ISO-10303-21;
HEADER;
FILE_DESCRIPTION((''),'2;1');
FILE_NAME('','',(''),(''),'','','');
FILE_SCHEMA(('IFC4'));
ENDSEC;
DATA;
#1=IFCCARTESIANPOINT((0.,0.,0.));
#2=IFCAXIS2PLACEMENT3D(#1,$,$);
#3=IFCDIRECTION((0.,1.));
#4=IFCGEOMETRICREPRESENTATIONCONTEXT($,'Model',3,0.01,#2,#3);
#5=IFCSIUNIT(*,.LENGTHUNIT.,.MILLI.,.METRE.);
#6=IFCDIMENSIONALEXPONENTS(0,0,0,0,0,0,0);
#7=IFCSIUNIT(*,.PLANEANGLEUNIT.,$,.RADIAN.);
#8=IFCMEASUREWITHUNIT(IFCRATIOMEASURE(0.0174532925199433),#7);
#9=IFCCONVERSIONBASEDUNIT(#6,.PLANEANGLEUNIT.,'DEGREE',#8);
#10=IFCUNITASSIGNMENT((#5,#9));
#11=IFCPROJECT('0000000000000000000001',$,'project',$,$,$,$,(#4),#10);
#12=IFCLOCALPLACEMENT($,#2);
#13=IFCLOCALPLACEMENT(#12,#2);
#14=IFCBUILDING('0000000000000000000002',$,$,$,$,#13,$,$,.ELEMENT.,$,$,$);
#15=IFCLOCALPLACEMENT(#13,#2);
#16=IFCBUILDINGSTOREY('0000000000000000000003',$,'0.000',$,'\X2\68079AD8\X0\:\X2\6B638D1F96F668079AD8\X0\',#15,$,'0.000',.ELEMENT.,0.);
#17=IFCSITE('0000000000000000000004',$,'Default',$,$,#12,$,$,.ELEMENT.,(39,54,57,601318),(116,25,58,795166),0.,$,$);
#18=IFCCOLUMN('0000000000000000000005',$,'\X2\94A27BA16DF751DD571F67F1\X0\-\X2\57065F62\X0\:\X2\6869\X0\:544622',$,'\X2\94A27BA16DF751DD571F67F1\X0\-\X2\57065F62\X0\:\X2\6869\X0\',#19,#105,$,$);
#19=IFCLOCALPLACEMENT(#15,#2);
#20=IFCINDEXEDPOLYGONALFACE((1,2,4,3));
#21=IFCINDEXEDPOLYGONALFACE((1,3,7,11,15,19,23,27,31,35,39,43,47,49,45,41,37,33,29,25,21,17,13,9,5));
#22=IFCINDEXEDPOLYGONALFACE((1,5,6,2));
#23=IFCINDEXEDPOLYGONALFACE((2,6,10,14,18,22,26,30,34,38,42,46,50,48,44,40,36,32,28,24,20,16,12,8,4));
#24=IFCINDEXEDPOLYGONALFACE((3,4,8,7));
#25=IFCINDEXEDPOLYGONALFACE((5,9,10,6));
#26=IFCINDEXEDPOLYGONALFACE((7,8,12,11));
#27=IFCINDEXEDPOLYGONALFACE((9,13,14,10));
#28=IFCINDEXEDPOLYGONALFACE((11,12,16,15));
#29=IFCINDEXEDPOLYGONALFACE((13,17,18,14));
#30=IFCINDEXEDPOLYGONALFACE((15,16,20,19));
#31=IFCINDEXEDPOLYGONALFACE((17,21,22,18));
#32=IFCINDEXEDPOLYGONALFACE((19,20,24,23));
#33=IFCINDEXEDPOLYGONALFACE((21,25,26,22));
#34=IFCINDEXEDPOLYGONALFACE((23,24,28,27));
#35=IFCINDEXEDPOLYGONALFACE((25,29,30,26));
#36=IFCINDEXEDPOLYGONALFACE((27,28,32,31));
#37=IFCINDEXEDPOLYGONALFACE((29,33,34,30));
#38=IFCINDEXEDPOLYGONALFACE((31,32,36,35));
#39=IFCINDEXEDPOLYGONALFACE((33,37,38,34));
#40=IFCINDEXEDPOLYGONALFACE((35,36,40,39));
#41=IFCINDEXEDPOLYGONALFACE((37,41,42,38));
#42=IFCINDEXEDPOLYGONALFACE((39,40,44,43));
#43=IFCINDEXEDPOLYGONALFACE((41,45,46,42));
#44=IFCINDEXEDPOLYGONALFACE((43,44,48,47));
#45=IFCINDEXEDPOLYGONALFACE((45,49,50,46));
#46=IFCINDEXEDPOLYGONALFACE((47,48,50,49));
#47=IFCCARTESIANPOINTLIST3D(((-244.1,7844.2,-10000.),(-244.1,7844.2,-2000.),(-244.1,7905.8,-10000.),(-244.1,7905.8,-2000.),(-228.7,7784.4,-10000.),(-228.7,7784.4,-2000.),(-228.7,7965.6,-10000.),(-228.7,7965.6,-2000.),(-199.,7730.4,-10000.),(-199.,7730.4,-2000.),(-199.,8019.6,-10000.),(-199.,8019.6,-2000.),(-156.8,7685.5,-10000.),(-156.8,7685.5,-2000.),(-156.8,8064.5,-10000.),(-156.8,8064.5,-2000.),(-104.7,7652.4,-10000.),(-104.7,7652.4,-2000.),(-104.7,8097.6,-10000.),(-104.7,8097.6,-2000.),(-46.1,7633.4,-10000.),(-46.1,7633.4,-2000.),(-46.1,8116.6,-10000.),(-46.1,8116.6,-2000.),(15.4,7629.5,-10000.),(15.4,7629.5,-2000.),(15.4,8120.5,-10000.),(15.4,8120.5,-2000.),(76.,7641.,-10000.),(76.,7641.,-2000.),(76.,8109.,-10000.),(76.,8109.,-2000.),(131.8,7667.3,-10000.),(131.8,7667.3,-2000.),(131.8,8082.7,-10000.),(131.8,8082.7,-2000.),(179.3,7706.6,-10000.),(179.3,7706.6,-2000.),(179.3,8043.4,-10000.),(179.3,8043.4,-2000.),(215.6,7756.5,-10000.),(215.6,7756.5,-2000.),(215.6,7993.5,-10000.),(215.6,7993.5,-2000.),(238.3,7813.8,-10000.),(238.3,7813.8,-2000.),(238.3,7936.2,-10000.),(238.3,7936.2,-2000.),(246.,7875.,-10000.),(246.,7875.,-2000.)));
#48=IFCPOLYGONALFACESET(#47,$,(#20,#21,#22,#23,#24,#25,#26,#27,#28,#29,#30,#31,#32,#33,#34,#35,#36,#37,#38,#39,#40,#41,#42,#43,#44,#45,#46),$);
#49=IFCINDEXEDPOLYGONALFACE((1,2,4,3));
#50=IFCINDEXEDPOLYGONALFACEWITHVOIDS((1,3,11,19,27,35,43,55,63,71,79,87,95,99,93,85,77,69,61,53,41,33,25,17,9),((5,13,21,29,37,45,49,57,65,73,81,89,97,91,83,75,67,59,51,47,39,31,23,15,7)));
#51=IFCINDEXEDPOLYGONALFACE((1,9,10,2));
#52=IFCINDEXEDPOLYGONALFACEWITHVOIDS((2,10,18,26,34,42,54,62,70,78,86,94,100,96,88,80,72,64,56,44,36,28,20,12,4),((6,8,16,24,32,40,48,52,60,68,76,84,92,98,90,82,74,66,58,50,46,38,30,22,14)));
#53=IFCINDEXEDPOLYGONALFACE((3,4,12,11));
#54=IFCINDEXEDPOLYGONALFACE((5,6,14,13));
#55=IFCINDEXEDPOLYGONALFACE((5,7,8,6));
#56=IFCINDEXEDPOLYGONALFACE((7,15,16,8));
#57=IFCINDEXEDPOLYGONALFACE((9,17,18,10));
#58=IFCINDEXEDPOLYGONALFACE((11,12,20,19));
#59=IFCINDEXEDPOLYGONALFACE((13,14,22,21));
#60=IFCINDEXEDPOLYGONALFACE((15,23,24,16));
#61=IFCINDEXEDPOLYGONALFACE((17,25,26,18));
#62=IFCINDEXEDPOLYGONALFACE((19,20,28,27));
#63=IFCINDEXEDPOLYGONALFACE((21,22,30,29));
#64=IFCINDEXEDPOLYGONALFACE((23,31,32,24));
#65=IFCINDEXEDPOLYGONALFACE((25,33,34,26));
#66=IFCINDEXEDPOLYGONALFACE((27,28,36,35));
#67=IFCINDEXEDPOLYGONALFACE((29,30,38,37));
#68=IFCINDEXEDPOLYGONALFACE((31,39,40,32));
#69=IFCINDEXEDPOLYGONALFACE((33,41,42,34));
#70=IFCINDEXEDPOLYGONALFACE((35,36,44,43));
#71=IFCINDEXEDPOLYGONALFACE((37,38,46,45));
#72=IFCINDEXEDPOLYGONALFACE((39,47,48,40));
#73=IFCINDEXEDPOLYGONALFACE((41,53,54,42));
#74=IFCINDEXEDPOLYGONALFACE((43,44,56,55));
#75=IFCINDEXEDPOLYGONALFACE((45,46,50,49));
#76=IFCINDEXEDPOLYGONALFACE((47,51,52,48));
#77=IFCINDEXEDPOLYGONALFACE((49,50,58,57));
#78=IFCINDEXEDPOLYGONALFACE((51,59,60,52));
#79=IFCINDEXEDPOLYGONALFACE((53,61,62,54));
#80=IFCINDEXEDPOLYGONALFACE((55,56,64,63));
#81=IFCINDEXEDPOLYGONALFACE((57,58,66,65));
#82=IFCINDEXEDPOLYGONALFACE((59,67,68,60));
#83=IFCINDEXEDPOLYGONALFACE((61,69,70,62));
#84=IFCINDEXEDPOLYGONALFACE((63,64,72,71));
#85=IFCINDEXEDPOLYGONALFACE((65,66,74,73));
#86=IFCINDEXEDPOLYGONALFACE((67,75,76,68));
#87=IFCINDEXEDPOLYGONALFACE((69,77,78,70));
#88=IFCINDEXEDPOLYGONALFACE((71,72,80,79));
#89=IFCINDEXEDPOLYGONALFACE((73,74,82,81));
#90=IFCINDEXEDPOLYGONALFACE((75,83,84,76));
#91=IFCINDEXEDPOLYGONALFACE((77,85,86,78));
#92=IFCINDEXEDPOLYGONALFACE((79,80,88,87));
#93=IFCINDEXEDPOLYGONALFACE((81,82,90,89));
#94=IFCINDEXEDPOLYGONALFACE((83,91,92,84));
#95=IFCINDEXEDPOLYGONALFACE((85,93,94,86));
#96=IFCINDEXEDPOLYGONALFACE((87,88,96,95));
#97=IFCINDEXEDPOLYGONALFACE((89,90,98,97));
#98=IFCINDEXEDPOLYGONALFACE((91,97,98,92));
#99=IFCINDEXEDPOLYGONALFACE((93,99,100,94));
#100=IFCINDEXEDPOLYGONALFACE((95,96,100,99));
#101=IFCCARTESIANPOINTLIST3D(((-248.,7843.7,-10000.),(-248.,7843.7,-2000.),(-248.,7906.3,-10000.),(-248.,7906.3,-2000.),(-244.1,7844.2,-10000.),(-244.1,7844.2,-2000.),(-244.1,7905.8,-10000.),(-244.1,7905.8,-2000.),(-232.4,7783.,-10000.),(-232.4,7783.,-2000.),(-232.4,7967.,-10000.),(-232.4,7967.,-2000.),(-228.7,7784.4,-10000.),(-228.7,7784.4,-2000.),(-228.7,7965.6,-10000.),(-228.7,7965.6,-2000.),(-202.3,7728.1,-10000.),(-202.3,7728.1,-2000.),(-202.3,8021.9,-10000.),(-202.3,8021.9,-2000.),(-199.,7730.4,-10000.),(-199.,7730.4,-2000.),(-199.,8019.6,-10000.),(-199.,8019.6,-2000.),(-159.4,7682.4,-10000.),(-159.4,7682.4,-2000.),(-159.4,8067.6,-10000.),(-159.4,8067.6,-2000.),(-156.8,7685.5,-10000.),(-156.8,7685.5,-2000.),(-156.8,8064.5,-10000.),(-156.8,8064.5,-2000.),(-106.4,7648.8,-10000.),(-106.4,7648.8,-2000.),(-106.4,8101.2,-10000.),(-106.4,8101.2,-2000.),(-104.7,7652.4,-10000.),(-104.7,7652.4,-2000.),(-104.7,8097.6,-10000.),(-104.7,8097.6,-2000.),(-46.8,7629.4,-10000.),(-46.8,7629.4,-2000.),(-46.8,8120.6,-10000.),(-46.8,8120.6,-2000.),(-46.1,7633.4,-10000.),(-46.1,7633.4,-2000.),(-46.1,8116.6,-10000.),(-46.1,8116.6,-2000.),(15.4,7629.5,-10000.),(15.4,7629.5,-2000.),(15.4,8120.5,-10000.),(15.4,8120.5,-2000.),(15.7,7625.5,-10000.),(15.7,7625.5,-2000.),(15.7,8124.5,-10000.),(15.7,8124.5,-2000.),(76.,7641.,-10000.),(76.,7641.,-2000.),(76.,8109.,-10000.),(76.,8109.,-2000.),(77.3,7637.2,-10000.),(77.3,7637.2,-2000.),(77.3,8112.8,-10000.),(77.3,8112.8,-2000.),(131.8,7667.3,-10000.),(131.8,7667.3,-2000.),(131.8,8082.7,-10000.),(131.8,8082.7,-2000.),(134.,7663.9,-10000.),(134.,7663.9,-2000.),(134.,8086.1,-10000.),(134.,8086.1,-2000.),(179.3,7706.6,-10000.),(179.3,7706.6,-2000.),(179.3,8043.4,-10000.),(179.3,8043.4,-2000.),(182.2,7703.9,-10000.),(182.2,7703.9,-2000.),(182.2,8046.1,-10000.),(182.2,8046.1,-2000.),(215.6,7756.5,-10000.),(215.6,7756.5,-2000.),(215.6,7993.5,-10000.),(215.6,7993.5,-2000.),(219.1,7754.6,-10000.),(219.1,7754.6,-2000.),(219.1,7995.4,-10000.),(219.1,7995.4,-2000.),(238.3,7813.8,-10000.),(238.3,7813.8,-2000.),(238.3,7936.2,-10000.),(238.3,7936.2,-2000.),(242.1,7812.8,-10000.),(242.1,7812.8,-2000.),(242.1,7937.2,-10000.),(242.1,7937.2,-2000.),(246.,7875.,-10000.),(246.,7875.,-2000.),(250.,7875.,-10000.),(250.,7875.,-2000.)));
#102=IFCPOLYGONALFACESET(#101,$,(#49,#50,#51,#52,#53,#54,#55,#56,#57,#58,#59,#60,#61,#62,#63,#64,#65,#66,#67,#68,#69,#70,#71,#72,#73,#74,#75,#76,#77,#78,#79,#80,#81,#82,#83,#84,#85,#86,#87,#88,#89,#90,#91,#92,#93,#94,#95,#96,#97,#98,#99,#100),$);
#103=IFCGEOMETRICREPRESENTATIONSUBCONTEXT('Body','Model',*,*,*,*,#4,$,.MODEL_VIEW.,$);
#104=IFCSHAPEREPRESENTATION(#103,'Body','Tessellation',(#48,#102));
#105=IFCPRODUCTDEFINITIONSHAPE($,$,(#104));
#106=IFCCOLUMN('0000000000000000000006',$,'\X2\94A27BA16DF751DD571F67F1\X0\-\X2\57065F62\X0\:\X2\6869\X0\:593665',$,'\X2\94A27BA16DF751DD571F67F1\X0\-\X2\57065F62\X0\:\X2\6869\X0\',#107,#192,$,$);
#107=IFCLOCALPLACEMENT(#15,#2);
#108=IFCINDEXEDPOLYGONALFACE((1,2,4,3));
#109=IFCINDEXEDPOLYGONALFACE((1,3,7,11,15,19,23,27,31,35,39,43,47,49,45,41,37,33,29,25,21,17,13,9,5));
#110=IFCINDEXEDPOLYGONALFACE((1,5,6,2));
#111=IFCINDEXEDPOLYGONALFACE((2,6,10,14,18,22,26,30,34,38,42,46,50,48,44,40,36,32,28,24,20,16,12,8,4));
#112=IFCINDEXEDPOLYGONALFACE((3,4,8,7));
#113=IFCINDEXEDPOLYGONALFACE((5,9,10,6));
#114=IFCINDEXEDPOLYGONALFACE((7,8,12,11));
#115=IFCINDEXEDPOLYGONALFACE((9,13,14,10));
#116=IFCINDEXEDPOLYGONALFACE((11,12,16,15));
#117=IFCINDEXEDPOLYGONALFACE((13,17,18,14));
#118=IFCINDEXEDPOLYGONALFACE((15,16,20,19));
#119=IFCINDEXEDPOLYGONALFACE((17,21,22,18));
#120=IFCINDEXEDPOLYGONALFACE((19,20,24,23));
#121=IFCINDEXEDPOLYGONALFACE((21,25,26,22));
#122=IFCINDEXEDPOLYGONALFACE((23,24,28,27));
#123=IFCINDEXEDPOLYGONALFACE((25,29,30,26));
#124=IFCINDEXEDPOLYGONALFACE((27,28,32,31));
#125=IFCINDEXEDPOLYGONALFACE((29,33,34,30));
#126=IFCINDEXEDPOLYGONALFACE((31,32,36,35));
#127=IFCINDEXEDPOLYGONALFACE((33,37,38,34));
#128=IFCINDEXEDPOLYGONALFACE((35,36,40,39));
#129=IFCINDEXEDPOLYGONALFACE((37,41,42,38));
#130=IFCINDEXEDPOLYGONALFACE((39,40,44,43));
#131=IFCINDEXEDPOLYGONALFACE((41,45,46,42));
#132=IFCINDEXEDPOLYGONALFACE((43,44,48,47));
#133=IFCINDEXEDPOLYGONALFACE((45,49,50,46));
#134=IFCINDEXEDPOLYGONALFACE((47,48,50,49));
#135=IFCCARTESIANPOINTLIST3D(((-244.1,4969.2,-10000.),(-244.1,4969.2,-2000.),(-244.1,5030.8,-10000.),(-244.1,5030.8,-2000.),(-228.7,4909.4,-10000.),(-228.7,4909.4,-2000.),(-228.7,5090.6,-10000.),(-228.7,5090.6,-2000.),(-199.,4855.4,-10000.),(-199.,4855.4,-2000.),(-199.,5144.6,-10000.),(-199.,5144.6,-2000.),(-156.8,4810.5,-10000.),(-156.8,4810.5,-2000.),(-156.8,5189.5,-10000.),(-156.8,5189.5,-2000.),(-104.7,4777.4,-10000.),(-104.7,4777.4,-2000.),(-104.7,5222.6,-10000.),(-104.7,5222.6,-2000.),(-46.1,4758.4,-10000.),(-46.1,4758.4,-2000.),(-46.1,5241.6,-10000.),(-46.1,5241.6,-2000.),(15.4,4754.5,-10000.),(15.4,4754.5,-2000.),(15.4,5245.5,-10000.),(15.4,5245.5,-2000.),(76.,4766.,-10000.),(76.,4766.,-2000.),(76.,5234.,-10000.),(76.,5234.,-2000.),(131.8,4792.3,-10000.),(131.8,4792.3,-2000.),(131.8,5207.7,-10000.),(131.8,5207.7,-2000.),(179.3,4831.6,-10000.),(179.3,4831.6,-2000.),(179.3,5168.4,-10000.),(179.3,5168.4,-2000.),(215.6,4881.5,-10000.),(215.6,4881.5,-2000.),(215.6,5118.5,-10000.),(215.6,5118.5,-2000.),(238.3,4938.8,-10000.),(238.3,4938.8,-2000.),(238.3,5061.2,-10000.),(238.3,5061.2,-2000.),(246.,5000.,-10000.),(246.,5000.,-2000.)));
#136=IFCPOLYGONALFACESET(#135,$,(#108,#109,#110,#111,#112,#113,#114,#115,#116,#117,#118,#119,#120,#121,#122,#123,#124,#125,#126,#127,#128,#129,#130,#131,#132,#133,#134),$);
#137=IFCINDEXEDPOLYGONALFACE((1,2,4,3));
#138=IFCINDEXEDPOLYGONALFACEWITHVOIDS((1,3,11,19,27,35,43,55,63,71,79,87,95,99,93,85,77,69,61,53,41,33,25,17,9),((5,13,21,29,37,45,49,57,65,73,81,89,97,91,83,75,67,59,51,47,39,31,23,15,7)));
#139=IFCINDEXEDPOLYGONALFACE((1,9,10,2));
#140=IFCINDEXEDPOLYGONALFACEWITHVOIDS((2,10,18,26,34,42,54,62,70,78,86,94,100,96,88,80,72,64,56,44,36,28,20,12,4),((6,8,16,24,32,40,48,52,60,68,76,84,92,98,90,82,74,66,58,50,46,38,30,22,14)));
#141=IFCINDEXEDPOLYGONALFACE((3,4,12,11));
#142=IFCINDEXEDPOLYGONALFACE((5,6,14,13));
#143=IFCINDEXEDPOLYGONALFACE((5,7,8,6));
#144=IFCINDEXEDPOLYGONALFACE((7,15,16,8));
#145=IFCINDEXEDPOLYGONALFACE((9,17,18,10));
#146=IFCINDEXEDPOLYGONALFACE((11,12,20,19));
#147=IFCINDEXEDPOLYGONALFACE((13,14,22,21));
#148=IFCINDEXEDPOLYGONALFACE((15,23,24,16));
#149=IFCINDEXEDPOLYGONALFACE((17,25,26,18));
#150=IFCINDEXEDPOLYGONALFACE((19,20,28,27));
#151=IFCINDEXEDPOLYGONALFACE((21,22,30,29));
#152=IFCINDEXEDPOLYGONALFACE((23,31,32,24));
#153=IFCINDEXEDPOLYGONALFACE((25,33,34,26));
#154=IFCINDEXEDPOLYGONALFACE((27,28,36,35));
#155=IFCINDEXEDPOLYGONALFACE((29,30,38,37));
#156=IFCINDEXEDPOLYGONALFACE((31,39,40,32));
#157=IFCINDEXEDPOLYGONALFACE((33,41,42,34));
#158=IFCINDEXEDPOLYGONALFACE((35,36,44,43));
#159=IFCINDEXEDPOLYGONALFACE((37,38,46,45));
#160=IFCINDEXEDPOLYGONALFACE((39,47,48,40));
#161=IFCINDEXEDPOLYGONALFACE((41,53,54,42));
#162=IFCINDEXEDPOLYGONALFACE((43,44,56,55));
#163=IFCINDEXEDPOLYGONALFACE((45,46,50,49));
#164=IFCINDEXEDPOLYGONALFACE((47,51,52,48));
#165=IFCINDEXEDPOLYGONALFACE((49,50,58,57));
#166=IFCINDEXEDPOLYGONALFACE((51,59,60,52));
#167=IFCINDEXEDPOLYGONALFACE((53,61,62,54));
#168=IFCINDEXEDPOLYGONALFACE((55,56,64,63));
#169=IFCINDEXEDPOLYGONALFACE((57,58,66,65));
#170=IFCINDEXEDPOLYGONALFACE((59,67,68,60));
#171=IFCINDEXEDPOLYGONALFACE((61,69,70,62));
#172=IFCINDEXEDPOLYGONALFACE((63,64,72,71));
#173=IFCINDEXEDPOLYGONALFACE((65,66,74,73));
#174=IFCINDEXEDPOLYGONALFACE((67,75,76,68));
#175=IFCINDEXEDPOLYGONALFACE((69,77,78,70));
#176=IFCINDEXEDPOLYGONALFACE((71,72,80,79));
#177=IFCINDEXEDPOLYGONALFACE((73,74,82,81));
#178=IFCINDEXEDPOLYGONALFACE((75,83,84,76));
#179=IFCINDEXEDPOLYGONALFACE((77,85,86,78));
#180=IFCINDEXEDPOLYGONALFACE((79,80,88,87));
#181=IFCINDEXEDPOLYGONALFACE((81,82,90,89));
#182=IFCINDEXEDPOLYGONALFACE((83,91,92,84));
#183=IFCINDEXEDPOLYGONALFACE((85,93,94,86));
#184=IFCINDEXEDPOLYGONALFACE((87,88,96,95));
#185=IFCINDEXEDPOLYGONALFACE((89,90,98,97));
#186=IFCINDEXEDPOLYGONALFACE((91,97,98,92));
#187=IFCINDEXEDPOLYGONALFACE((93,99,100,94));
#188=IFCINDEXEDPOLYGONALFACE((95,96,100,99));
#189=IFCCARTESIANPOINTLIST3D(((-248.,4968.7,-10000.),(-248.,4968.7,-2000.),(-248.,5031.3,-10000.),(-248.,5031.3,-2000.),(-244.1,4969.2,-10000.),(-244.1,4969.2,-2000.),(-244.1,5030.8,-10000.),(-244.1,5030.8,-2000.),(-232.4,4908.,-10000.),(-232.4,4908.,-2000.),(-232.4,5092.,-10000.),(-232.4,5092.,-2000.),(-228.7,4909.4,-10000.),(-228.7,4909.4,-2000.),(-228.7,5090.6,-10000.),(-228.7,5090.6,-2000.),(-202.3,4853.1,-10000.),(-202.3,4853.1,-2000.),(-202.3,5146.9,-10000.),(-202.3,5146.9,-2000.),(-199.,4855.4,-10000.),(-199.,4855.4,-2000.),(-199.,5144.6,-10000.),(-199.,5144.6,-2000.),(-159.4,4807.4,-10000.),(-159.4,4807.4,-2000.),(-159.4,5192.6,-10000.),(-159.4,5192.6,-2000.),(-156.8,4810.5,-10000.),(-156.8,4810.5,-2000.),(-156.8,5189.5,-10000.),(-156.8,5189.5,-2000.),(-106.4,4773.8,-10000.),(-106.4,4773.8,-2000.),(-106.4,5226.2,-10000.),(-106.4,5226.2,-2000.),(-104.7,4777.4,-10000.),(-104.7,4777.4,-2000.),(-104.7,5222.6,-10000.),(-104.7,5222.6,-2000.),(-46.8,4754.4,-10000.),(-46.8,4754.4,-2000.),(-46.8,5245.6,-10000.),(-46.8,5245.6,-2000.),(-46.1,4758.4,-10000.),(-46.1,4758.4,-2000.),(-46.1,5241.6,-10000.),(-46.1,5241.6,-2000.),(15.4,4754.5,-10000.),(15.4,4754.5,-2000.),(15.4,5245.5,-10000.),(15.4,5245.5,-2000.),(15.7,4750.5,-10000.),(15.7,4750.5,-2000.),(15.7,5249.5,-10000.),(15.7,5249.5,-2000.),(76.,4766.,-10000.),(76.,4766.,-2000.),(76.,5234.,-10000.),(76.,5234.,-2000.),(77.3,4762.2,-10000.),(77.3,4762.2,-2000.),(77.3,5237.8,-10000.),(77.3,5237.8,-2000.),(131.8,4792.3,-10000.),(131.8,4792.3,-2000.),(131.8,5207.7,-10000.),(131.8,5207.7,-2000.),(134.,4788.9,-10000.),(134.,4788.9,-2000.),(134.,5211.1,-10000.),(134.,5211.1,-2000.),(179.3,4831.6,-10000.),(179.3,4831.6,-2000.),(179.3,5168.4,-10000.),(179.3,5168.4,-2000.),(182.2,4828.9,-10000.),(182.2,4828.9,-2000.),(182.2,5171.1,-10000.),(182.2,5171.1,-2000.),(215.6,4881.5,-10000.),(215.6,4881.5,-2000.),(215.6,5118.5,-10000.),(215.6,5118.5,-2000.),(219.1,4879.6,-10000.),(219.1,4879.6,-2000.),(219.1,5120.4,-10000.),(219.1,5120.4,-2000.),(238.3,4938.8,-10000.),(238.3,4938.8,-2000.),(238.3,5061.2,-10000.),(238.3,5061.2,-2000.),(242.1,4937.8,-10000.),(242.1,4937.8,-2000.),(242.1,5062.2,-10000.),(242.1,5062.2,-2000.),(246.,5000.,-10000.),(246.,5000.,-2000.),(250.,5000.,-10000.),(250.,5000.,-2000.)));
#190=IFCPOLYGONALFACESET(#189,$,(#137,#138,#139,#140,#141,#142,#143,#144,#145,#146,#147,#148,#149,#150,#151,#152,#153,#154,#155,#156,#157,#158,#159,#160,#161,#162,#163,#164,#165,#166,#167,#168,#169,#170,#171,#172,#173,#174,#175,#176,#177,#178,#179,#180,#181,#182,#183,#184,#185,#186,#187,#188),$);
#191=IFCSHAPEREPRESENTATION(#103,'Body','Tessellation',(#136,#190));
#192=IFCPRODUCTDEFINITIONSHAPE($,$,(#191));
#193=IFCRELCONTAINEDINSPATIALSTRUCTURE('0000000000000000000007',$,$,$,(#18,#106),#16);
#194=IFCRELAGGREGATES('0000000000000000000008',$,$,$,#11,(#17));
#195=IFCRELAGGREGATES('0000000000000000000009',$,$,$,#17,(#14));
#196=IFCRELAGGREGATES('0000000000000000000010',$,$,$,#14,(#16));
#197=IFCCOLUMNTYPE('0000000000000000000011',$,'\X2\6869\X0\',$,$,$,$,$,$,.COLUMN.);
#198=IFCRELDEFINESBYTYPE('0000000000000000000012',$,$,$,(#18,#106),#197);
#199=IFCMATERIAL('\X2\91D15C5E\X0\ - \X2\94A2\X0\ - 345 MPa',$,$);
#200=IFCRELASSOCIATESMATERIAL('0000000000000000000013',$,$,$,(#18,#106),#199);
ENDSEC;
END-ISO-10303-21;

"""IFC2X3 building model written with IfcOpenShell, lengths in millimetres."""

from ifc_helpers import new_model, entity, si_unit, converted_unit, direction, frame, frame_2d, origin, place, context, subcontext, project, spatial, circle, hollow_circle, extrude, source, transform, mapped, material, type_object, type_shapes, element, save


model = new_model("IFC2X3")

# Units and contexts
model_context = context("Model", 3, precision=0.01, world=origin(), true_north=direction((0.0, 1.0)))
body_context = subcontext(model_context, "Body", "Model", "MODEL_VIEW")
ifc_project = project(units=[si_unit("LENGTHUNIT", "METRE", prefix="MILLI"), converted_unit("PLANEANGLEUNIT", "DEGREE", entity("IfcRatioMeasure", 0.0174532925199433), si_unit("PLANEANGLEUNIT", "RADIAN"), dimensions=[0, 0, 0, 0, 0, 0, 0])], contexts=[model_context])

# Site, building, storey
site_placement = place(None, origin())
site = spatial("IfcSite", under=ifc_project, at=site_placement, Name="Default", CompositionType="ELEMENT", RefLatitude=(39, 54, 57, 601318), RefLongitude=(116, 25, 58, 795166), RefElevation=0.0)
building_placement = place(site_placement, origin())
building = spatial("IfcBuilding", under=site, at=building_placement, CompositionType="ELEMENT")
storey_placement = place(building_placement, origin())
storey = spatial("IfcBuildingStorey", under=building, at=storey_placement, Name="0.000", ObjectType="标高:正负零标高", LongName="0.000", CompositionType="ELEMENT", Elevation=0.0)

# Columns
ifc_material_1 = material(Name="金属 - 钢 - 345 MPa")
column_type_1 = type_object("IfcColumnType", Name="桩", PredefinedType="COLUMN")
shared_shape_1 = source(origin(), body_context, "Body", "SweptSolid", [
    extrude(circle(Radius=246.0, at=frame_2d((0.0, 0.0), x_axis=(1.0, 0.0))), frame((0.0, 0.0, -10000.0)), (0.0, 0.0, 1.0), 8000.0),
    extrude(hollow_circle(Radius=250.0, WallThickness=4.0, at=frame_2d((0.0, 0.0), x_axis=(1.0, 0.0))), frame((0.0, 0.0, -10000.0)), (0.0, 0.0, 1.0), 8000.0),
])
type_shapes(column_type_1, [shared_shape_1])
for number, where, name in (
    (1, (0.0, 7875.0, 0.0), "钢管混凝土柱-圆形:桩:544622"),
    (2, (0.0, 5000.0, 0.0), "钢管混凝土柱-圆形:桩:593665"),
):
    element("IfcColumn", number, at=place(storey_placement, frame(where)), inside=storey, type_object=column_type_1, material=ifc_material_1, Name=name, ObjectType="钢管混凝土柱-圆形:桩", context=body_context, shape_type="MappedRepresentation", body=[
        mapped(shared_shape_1, transform((0.0, 0.0, 0.0), scale=1.0)),
    ])

save(model, "model.ifc")
